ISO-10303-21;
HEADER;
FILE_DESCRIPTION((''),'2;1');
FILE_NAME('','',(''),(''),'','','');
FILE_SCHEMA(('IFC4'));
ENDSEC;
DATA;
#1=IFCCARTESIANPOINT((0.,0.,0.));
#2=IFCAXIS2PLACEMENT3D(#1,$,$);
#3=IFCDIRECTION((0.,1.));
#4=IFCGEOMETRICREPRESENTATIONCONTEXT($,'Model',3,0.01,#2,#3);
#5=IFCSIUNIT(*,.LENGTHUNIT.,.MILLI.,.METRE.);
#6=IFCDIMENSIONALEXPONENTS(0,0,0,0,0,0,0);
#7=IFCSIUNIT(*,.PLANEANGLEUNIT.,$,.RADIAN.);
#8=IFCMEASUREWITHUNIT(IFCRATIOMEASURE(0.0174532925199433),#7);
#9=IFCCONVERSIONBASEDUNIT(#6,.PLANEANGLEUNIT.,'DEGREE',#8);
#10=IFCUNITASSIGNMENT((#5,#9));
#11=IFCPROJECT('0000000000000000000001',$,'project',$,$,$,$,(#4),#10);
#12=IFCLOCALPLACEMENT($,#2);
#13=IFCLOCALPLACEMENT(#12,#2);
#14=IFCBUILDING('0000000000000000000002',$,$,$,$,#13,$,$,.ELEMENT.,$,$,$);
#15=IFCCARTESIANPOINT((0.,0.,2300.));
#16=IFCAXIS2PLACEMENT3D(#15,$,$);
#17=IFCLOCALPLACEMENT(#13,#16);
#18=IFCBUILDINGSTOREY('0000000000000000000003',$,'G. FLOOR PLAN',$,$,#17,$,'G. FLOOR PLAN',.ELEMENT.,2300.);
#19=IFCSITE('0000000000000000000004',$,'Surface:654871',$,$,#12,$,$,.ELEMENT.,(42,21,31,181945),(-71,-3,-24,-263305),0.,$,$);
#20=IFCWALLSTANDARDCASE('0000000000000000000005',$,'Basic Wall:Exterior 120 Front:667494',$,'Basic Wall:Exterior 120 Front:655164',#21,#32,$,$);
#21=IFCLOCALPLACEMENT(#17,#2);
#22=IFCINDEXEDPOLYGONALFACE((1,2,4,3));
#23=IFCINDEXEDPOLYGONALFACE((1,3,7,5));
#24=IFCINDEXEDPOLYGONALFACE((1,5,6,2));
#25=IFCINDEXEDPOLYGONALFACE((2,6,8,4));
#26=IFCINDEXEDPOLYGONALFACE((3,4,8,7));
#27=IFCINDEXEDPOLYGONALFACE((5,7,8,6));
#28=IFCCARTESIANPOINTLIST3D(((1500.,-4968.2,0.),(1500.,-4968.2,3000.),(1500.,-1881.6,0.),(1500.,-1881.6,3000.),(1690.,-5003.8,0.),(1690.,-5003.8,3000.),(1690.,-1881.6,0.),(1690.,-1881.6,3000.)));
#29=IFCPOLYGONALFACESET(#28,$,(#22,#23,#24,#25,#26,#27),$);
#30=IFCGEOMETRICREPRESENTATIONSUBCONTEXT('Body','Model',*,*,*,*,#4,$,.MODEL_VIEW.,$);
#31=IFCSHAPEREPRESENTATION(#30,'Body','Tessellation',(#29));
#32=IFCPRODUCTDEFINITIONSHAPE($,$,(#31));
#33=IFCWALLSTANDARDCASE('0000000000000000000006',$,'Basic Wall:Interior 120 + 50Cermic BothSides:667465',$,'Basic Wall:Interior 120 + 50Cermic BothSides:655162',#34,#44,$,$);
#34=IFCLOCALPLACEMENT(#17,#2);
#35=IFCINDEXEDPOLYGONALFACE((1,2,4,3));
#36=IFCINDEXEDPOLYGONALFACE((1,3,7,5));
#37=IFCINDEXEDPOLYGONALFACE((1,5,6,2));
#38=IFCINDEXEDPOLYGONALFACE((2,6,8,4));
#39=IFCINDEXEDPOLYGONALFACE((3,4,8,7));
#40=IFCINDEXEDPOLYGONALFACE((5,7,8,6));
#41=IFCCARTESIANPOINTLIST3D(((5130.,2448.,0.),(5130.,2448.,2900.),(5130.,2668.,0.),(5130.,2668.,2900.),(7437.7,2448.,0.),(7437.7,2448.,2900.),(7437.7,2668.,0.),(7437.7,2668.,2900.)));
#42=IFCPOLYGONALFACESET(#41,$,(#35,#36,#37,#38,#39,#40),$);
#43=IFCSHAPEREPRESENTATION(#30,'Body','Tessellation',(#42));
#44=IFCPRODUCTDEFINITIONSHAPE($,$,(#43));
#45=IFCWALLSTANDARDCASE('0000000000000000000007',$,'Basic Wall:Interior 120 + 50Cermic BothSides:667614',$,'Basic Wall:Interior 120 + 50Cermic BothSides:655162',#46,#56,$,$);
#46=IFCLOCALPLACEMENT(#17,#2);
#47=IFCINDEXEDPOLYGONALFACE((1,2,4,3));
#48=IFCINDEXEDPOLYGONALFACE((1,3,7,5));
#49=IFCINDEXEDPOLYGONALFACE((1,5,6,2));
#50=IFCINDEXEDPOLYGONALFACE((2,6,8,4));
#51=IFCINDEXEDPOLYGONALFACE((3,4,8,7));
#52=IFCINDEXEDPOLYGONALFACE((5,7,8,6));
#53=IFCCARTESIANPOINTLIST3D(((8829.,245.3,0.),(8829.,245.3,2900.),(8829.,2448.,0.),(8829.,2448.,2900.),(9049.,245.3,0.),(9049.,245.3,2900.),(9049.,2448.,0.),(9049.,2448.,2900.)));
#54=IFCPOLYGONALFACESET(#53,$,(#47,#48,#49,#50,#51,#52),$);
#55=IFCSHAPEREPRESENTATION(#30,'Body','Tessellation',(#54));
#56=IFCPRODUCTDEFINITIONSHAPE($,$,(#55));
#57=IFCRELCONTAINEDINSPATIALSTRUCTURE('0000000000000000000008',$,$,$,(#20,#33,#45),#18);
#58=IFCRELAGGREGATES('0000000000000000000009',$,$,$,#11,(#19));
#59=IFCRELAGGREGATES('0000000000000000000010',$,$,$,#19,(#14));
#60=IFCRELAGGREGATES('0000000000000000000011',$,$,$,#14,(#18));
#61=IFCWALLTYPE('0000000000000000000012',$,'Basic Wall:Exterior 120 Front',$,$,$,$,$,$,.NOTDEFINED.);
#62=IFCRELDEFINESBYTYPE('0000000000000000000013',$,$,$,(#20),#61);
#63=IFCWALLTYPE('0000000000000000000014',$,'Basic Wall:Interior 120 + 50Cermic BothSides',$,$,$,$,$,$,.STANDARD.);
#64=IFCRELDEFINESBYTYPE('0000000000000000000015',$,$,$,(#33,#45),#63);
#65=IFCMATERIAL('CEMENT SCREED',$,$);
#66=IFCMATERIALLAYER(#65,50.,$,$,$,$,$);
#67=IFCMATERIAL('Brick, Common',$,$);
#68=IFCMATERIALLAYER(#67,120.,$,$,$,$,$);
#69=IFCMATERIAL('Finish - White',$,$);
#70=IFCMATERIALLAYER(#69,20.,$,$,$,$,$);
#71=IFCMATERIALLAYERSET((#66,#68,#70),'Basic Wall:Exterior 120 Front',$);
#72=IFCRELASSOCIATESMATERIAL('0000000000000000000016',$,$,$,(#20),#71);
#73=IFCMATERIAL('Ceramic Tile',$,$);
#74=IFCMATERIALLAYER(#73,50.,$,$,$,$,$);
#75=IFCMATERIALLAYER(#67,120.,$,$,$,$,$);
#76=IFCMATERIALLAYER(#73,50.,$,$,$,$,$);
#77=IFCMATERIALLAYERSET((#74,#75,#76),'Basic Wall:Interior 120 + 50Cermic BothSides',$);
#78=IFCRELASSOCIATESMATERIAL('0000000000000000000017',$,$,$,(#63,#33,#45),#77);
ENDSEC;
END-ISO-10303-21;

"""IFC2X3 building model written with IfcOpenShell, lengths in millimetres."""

from ifc_helpers import new_model, entity, si_unit, converted_unit, direction, frame, frame_2d, origin, place, context, subcontext, project, spatial, polyline, rectangle, outline, extrude, clip, bounded_halfspace, material, layer, layer_set, layer_usage, type_object, element, save


model = new_model("IFC2X3")

# Units and contexts
model_context = context("Model", 3, precision=0.01, world=origin(), true_north=direction((0.0, 1.0)))
body_context = subcontext(model_context, "Body", "Model", "MODEL_VIEW")
ifc_project = project(units=[si_unit("LENGTHUNIT", "METRE", prefix="MILLI"), converted_unit("PLANEANGLEUNIT", "DEGREE", entity("IfcRatioMeasure", 0.0174532925199433), si_unit("PLANEANGLEUNIT", "RADIAN"), dimensions=[0, 0, 0, 0, 0, 0, 0])], contexts=[model_context])

# Site, building, storey
site_placement = place(None, origin())
site = spatial("IfcSite", under=ifc_project, at=site_placement, Name="Surface:654871", CompositionType="ELEMENT", RefLatitude=(42, 21, 31, 181945), RefLongitude=(-71, -3, -24, -263305), RefElevation=0.0)
building_placement = place(site_placement, origin())
building = spatial("IfcBuilding", under=site, at=building_placement, CompositionType="ELEMENT")
storey_placement = place(building_placement, frame((0.0, 0.0, 2300.0)))
storey = spatial("IfcBuildingStorey", under=building, at=storey_placement, Name="G. FLOOR PLAN", LongName="G. FLOOR PLAN", CompositionType="ELEMENT", Elevation=2300.0)

# Shared definitions
ifc_material_1 = material(Name="Brick, Common")
ifc_material_2 = material(Name="Finish - White")

# Shared definitions
ifc_material_3 = material(Name="Ceramic Tile")

# Shared definitions
ifc_material_4 = material(Name="CEMENT SCREED")
ifc_layer_1 = layer(ifc_material_4, 50.0)
ifc_layer_2 = layer(ifc_material_1, 120.0)
ifc_layer_3 = layer(ifc_material_2, 20.0)
ifc_layer_set_1 = layer_set([ifc_layer_1, ifc_layer_2, ifc_layer_3], Name="Basic Wall:Exterior 120 Front")
wall_type_1 = type_object("IfcWallType", Name="Basic Wall:Exterior 120 Front", PredefinedType="NOTDEFINED")

# Walls
ifc_layer_usage_1 = layer_usage(ifc_layer_set_1, "AXIS2", "NEGATIVE", 95.0)
wall_1_placement = place(storey_placement, frame((1595.0, -5003.8, 0.0), z_axis=(0.0, 0.0, 1.0), x_axis=(0.0, 1.0, 0.0)))
element("IfcWallStandardCase", 1, at=wall_1_placement, inside=storey, type_object=wall_type_1, material=ifc_layer_usage_1, Name="Basic Wall:Exterior 120 Front:667494", ObjectType="Basic Wall:Exterior 120 Front:655164", context=body_context, shape_type="Clipping", body=[
    clip(extrude(outline(polyline([(0.0, -95.0), (3122.1, -95.0), (3122.1, 95.0), (35.6, 95.0), (0.0, -95.0)])), origin(), (0.0, 0.0, 1.0), 3000.0), bounded_halfspace(frame((3122.1, -95.0, 0.0), z_axis=(0.0, 0.0, 1.0), x_axis=(0.190786, 0.981632, 0.0)), True, frame((3122.1, -95.0, 0.0)), polyline([(0.0, 0.0), (0.0, 190.0), (-341.0, 190.0), (-501.0, 190.0), (-3086.5, 190.0), (-3122.1, 0.0), (0.0, 0.0)]))),
])
ifc_layer_4 = layer(ifc_material_3, 50.0)
ifc_layer_5 = layer(ifc_material_1, 120.0)
ifc_layer_6 = layer(ifc_material_3, 50.0)
ifc_layer_set_2 = layer_set([ifc_layer_4, ifc_layer_5, ifc_layer_6], Name="Basic Wall:Interior 120 + 50Cermic BothSides")
ifc_layer_usage_2 = layer_usage(ifc_layer_set_2, "AXIS2", "POSITIVE", -110.0)
wall_type_2 = type_object("IfcWallType", Name="Basic Wall:Interior 120 + 50Cermic BothSides", PredefinedType="STANDARD", material=ifc_layer_set_2)
wall_2_placement = place(storey_placement, frame((7437.7, 2558.0, 0.0), z_axis=(0.0, 0.0, 1.0), x_axis=(-1.0, 0.0, 0.0)))
element("IfcWallStandardCase", 2, at=wall_2_placement, inside=storey, type_object=wall_type_2, material=ifc_layer_usage_2, Name="Basic Wall:Interior 120 + 50Cermic BothSides:667465", ObjectType="Basic Wall:Interior 120 + 50Cermic BothSides:655162", context=body_context, shape_type="SweptSolid", body=[
    extrude(rectangle(XDim=2307.7, YDim=220.0, at=frame_2d((1153.9, 0.0), x_axis=(-1.0, 0.0))), origin(), (0.0, 0.0, 1.0), 2900.0),
])
ifc_layer_usage_3 = layer_usage(ifc_layer_set_2, "AXIS2", "NEGATIVE", 110.0)
wall_3_placement = place(storey_placement, frame((8939.0, 2448.0, 0.0), z_axis=(0.0, 0.0, 1.0), x_axis=(0.0, -1.0, 0.0)))
element("IfcWallStandardCase", 3, at=wall_3_placement, inside=storey, type_object=wall_type_2, material=ifc_layer_usage_3, Name="Basic Wall:Interior 120 + 50Cermic BothSides:667614", ObjectType="Basic Wall:Interior 120 + 50Cermic BothSides:655162", context=body_context, shape_type="SweptSolid", body=[
    extrude(rectangle(XDim=2202.7, YDim=220.0, at=frame_2d((1101.4, 0.0), x_axis=(-1.0, 0.0))), origin(), (0.0, 0.0, 1.0), 2900.0),
])

save(model, "model.ifc")
